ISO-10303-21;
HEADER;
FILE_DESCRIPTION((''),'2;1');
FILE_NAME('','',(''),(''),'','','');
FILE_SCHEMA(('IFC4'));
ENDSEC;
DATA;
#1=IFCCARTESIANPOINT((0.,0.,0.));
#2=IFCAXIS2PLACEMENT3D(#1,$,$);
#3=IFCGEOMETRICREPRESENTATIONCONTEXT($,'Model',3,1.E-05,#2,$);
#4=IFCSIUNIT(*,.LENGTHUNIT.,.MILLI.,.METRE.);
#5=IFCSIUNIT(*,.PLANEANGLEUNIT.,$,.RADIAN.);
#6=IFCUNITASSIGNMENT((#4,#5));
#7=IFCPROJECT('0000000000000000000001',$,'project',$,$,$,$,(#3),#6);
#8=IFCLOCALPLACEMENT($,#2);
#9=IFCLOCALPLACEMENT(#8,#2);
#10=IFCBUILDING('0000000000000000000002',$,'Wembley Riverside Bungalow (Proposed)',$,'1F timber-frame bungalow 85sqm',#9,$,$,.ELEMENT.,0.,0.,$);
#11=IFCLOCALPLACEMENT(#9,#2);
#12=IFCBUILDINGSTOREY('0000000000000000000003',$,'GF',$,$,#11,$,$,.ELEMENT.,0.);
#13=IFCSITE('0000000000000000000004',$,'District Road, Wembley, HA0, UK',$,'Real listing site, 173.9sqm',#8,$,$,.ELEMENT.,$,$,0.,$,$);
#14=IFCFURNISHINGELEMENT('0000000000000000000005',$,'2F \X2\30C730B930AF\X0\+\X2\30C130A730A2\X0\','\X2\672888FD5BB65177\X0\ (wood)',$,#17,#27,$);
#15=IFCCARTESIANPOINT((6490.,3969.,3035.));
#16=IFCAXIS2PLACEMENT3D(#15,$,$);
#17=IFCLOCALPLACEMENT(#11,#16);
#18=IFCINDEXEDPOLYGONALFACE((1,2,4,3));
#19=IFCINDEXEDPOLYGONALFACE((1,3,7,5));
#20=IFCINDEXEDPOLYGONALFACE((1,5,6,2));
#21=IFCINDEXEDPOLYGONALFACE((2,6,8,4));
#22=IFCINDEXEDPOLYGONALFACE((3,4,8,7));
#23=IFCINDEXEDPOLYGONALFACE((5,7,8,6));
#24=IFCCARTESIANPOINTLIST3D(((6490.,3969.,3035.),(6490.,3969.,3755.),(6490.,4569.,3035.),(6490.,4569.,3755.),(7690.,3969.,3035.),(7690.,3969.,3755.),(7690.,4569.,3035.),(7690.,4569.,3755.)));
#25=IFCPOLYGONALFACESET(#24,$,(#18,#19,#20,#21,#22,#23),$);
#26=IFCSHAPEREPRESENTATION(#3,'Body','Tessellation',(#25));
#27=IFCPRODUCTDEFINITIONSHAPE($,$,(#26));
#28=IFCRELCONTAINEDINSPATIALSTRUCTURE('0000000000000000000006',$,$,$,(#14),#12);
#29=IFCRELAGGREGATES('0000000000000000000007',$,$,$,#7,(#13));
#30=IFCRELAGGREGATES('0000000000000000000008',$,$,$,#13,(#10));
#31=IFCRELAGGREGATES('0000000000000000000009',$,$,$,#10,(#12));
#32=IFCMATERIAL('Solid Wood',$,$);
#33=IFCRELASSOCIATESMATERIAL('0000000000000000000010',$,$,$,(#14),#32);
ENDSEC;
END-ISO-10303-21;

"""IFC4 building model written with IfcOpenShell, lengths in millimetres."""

from ifc_helpers import new_model, si_unit, frame, frame_2d, origin, place, context, project, spatial, rectangle, extrude, material, element, save


model = new_model("IFC4")

# Units and contexts
model_context = context("Model", 3, precision=1e-05, world=origin())
ifc_project = project(units=[si_unit("LENGTHUNIT", "METRE", prefix="MILLI"), si_unit("PLANEANGLEUNIT", "RADIAN")], contexts=[model_context])

# Site, building, storey
site_placement = place(None, origin())
site = spatial("IfcSite", under=ifc_project, at=site_placement, Name="District Road, Wembley, HA0, UK", ObjectType="Real listing site, 173.9sqm", CompositionType="ELEMENT", RefElevation=0.0)
building_placement = place(site_placement, origin())
building = spatial("IfcBuilding", under=site, at=building_placement, Name="Wembley Riverside Bungalow (Proposed)", ObjectType="1F timber-frame bungalow 85sqm", CompositionType="ELEMENT", ElevationOfRefHeight=0.0, ElevationOfTerrain=0.0)
storey_placement = place(building_placement, origin())
storey = spatial("IfcBuildingStorey", under=building, at=storey_placement, Name="GF", CompositionType="ELEMENT", Elevation=0.0)

# Shared definitions
ifc_material_1 = material(Name="Solid Wood")

# Furnishing element
furnishing_1_placement = place(storey_placement, frame((6490.0, 3969.0, 3035.0)))
element("IfcFurnishingElement", 1, at=furnishing_1_placement, inside=storey, material=ifc_material_1, Name="2F デスク+チェア", Description="木製家具 (wood)", context=model_context, shape_type="SweptSolid", body=[
    extrude(rectangle(XDim=1200.0, YDim=600.0, at=frame_2d((600.0, 300.0))), frame((6490.0, 3969.0, 3035.0)), (0.0, 0.0, 1.0), 720.0),
])

save(model, "model.ifc")
